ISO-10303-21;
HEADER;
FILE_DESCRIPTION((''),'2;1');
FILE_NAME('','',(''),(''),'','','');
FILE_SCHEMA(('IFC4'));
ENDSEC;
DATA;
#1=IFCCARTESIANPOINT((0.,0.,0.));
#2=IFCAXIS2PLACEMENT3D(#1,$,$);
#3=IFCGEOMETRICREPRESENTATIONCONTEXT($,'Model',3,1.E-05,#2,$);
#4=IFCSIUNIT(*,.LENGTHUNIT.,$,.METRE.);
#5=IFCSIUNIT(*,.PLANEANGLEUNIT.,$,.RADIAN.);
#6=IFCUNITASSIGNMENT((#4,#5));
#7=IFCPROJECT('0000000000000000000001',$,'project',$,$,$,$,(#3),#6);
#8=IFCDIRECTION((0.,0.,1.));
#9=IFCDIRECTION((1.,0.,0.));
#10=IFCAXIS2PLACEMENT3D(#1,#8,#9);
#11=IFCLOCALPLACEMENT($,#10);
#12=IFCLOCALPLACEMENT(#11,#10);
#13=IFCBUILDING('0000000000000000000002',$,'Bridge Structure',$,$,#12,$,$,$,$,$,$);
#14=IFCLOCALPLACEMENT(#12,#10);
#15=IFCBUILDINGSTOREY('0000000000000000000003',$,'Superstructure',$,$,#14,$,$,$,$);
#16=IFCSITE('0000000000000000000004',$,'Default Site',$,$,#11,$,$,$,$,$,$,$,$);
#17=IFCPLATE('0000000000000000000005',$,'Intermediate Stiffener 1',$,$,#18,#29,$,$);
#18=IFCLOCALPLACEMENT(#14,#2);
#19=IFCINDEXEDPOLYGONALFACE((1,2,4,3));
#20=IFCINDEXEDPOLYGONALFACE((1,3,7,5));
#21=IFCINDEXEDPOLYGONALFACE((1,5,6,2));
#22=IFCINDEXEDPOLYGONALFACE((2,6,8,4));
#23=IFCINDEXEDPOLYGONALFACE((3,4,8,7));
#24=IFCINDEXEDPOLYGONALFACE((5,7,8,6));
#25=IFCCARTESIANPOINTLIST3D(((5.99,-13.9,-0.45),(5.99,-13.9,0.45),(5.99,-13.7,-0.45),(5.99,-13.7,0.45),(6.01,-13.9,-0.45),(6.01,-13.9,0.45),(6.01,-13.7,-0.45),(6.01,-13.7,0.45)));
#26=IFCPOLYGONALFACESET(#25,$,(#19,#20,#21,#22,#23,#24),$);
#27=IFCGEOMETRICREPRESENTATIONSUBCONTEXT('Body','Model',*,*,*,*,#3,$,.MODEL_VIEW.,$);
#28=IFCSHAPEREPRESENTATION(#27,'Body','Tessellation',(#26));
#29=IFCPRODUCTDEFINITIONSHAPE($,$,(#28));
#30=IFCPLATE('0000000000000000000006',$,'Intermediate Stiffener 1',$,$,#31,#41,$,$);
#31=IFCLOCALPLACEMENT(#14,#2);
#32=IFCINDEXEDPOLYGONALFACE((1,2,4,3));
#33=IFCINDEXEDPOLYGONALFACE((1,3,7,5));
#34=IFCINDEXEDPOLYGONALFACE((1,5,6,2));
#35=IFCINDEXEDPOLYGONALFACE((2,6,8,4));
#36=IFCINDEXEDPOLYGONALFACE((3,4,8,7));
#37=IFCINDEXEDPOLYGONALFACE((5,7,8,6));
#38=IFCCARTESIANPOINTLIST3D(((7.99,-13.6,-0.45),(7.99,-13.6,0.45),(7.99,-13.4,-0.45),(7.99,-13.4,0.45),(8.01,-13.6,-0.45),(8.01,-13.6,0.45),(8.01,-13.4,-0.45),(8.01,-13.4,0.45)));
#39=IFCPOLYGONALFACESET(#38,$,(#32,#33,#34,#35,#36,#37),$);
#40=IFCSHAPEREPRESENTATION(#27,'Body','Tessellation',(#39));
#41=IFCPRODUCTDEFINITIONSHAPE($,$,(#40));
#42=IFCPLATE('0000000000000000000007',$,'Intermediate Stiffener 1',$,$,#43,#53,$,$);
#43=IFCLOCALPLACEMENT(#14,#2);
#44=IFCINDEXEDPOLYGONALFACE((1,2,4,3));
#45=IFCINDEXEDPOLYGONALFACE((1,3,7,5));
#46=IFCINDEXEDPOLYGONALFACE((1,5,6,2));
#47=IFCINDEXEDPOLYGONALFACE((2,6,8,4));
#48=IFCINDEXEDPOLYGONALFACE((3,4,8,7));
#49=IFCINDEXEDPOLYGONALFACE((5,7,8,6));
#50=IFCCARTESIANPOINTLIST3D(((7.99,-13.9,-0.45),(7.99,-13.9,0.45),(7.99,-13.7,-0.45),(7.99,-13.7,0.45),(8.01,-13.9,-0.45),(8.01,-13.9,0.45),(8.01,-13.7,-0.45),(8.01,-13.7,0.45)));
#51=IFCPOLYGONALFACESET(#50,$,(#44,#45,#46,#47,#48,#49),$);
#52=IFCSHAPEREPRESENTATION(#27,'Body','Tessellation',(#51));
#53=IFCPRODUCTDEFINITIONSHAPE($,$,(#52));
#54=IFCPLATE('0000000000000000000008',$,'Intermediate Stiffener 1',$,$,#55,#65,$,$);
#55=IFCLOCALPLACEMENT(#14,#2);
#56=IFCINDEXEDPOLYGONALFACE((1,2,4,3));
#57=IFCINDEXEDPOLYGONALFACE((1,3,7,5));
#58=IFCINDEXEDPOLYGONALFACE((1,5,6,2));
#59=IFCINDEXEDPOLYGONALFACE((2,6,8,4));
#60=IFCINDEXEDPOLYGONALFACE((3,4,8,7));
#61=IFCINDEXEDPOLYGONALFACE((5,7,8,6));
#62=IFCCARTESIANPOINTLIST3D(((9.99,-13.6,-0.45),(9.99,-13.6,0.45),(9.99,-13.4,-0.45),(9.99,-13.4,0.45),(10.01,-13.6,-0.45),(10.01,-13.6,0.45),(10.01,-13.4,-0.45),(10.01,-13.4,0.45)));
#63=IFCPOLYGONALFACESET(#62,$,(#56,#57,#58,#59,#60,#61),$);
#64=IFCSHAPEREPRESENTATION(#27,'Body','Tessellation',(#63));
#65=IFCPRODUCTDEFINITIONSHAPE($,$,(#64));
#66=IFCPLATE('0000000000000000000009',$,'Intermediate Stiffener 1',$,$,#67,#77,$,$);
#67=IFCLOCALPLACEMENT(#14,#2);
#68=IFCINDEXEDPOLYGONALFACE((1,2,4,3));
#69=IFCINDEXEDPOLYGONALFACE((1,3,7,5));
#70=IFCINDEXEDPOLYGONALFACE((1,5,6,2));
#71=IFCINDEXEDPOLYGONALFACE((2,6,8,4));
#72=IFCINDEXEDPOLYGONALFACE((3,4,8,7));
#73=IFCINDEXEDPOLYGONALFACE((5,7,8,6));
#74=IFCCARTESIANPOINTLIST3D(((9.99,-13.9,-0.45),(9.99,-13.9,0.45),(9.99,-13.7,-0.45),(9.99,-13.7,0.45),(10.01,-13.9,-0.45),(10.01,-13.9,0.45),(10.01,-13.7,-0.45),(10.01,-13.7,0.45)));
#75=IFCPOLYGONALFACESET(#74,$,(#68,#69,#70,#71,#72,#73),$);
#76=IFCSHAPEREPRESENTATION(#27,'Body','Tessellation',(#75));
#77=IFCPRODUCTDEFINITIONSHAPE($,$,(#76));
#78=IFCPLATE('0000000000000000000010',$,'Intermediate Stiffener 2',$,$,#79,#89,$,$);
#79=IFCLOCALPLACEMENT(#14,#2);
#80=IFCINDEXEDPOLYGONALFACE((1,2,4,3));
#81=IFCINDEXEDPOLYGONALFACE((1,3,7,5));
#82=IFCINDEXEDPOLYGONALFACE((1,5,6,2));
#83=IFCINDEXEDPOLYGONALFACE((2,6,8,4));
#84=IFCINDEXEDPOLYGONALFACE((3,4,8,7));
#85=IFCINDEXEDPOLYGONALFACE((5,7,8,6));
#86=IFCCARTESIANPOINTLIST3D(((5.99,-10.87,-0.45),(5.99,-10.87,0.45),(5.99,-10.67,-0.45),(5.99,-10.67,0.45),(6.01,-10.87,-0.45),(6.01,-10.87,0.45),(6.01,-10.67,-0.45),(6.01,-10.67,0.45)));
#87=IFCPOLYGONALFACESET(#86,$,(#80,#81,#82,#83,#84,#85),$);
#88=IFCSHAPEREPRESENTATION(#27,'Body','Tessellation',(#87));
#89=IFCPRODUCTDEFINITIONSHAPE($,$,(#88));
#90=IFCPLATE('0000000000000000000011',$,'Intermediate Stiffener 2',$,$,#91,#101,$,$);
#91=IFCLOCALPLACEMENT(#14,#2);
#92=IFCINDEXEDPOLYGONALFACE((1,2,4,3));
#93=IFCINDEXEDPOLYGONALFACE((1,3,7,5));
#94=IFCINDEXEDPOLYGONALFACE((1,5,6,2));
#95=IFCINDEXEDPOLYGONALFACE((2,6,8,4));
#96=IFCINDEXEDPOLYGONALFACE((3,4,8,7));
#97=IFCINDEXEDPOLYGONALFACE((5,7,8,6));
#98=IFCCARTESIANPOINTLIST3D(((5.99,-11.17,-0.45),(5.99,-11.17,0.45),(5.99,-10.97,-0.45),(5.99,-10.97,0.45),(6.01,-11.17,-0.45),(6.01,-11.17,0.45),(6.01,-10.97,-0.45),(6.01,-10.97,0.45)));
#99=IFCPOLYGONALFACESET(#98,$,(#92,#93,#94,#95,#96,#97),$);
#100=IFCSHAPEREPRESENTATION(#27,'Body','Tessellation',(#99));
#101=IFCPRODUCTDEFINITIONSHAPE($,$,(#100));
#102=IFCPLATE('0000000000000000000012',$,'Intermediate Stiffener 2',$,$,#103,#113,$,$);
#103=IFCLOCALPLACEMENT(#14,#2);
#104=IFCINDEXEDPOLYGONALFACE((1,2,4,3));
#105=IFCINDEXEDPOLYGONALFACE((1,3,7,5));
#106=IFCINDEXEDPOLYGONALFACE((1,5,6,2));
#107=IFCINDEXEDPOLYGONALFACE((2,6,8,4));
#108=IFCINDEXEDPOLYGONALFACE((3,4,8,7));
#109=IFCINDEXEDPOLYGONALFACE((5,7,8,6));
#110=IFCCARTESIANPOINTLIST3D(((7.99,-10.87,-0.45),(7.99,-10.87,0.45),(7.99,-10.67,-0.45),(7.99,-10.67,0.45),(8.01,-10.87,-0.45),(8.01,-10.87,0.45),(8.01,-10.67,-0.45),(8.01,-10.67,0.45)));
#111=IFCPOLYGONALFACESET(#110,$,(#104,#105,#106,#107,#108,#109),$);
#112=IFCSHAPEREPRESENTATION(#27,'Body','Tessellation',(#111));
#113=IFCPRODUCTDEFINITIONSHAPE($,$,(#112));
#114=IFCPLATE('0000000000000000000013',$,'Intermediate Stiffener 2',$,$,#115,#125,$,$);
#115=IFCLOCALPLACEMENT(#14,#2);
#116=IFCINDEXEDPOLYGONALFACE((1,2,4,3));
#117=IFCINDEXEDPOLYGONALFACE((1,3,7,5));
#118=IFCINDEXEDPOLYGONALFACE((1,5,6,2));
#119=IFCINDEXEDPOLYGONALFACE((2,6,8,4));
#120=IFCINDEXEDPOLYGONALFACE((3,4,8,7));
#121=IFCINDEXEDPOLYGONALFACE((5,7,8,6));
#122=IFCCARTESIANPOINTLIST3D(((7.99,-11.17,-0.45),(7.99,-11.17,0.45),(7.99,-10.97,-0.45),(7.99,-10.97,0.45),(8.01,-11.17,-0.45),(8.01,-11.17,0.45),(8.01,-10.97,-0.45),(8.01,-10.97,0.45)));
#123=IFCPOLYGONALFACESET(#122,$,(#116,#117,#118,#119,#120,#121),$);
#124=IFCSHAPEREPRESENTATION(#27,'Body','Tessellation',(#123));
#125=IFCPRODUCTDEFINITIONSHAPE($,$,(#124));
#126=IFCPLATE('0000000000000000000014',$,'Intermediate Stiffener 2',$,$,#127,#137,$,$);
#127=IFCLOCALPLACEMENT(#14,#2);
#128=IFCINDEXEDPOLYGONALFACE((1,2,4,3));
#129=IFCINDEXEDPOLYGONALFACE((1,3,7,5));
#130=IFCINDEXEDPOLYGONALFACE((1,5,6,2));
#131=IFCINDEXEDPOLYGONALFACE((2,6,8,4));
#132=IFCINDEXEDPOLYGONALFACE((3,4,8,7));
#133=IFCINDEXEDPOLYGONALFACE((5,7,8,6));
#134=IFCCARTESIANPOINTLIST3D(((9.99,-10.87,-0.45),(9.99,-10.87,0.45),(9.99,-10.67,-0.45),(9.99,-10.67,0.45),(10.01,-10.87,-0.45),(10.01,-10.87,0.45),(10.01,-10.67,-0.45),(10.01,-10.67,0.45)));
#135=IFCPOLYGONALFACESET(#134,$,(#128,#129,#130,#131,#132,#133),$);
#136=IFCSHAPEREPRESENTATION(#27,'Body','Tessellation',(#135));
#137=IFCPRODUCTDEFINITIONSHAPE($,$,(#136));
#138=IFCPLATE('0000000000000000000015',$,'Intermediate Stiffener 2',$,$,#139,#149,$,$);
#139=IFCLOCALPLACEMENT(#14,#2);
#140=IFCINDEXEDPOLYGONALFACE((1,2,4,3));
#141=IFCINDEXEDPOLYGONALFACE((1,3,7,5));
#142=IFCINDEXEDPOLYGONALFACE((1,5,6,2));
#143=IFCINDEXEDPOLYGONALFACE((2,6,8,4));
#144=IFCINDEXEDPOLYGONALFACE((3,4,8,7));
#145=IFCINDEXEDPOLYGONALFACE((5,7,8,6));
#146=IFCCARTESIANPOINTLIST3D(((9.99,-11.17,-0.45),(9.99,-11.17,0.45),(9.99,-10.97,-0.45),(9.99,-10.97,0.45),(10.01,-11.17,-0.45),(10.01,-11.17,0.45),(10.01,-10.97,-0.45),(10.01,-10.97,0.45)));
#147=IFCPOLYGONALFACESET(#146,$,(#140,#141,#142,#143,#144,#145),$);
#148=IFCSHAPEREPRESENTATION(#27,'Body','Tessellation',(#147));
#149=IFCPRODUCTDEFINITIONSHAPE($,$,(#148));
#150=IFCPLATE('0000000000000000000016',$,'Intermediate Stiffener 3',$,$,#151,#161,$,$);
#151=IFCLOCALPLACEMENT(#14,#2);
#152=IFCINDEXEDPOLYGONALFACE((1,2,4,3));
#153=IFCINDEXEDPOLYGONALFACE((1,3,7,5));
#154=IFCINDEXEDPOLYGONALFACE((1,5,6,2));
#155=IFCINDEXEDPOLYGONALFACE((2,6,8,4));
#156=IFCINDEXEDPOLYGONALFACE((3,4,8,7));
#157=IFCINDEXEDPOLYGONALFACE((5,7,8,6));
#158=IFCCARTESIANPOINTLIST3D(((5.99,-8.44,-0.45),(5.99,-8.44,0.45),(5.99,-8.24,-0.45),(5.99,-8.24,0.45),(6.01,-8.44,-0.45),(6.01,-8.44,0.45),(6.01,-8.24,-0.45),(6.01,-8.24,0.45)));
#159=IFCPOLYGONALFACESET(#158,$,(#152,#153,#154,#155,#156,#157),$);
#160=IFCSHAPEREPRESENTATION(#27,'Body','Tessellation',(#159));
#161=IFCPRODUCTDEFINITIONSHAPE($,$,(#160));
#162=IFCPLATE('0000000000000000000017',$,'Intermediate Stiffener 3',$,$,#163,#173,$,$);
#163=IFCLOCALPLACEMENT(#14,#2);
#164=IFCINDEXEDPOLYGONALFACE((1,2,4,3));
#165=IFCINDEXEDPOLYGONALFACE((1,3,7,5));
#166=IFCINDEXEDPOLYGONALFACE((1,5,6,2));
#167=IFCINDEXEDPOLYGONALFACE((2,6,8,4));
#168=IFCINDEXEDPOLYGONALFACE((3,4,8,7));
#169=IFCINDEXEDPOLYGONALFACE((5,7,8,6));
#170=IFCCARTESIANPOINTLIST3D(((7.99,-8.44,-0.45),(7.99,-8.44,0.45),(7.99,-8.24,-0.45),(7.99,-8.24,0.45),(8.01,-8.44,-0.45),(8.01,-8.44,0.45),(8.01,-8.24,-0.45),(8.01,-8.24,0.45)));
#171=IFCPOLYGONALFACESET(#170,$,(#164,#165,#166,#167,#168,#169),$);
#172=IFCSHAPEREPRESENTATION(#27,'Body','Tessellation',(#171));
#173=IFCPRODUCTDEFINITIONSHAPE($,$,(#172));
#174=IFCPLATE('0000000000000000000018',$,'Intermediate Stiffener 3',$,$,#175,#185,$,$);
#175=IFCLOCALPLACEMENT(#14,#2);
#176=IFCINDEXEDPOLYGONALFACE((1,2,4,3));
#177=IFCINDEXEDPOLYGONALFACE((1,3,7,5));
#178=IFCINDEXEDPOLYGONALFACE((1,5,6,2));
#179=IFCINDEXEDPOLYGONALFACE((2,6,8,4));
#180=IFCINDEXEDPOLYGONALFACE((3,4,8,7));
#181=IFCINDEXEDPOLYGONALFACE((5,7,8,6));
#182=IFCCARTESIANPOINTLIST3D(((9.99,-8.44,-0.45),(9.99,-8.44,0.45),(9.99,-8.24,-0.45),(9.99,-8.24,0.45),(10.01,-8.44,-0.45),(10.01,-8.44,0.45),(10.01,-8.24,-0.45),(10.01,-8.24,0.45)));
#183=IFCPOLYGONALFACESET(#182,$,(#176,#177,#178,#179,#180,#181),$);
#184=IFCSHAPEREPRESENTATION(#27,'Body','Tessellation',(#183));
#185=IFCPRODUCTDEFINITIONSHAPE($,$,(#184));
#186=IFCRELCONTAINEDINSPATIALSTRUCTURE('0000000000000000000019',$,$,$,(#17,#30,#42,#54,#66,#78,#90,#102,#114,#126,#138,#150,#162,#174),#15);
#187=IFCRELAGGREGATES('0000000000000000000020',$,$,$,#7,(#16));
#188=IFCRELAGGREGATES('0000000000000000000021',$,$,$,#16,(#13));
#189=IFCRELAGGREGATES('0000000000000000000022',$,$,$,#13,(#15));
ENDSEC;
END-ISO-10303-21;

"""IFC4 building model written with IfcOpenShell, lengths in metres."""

from ifc_helpers import new_model, si_unit, frame, origin, origin_with_axes, origin_2d_with_axis, place, context, subcontext, project, spatial, rectangle, extrude, element, save


model = new_model("IFC4")

# Units and contexts
model_context = context("Model", 3, precision=1e-05, world=origin())
body_context = subcontext(model_context, "Body", "Model", "MODEL_VIEW")
ifc_project = project(units=[si_unit("LENGTHUNIT", "METRE"), si_unit("PLANEANGLEUNIT", "RADIAN")], contexts=[model_context])

# Site, building, storey
site_placement = place(None, origin_with_axes())
site = spatial("IfcSite", under=ifc_project, at=site_placement, Name="Default Site")
building_placement = place(site_placement, origin_with_axes())
building = spatial("IfcBuilding", under=site, at=building_placement, Name="Bridge Structure")
storey_placement = place(building_placement, origin_with_axes())
storey = spatial("IfcBuildingStorey", under=building, at=storey_placement, Name="Superstructure")

# Plates
for number, where, z_axis, x_axis, name in (
    (1, (6.0, -13.8, -0.45), (0.0, 0.0, 1.0), (1.0, 0.0, 0.0), "Intermediate Stiffener 1"),
    (2, (8.0, -13.5, -0.45), (0.0, 0.0, 1.0), (1.0, 0.0, 0.0), "Intermediate Stiffener 1"),
    (3, (8.0, -13.8, -0.45), (0.0, 0.0, 1.0), (1.0, 0.0, 0.0), "Intermediate Stiffener 1"),
    (4, (10.0, -13.5, -0.45), (0.0, 0.0, 1.0), (1.0, 0.0, 0.0), "Intermediate Stiffener 1"),
    (5, (10.0, -13.8, -0.45), (0.0, 0.0, 1.0), (1.0, 0.0, 0.0), "Intermediate Stiffener 1"),
    (6, (6.0, -10.77, -0.45), (0.0, 0.0, 1.0), (1.0, 0.0, 0.0), "Intermediate Stiffener 2"),
    (7, (6.0, -11.07, -0.45), (0.0, 0.0, 1.0), (1.0, 0.0, 0.0), "Intermediate Stiffener 2"),
    (8, (8.0, -10.77, -0.45), (0.0, 0.0, 1.0), (1.0, 0.0, 0.0), "Intermediate Stiffener 2"),
    (9, (8.0, -11.07, -0.45), (0.0, 0.0, 1.0), (1.0, 0.0, 0.0), "Intermediate Stiffener 2"),
    (10, (10.0, -10.77, -0.45), (0.0, 0.0, 1.0), (1.0, 0.0, 0.0), "Intermediate Stiffener 2"),
    (11, (10.0, -11.07, -0.45), (0.0, 0.0, 1.0), (1.0, 0.0, 0.0), "Intermediate Stiffener 2"),
    (12, (6.0, -8.34, -0.45), (0.0, 0.0, 1.0), (1.0, 0.0, 0.0), "Intermediate Stiffener 3"),
    (13, (8.0, -8.34, -0.45), (0.0, 0.0, 1.0), (1.0, 0.0, 0.0), "Intermediate Stiffener 3"),
    (14, (10.0, -8.34, -0.45), (0.0, 0.0, 1.0), (1.0, 0.0, 0.0), "Intermediate Stiffener 3"),
):
    element("IfcPlate", number, at=place(storey_placement, frame(where, z_axis=z_axis, x_axis=x_axis)), inside=storey, Name=name, context=body_context, shape_type="SweptSolid", body=[
        extrude(rectangle(XDim=0.02, YDim=0.2, at=origin_2d_with_axis()), origin_with_axes(), (0.0, 0.0, 1.0), 0.9),
    ])

save(model, "model.ifc")
